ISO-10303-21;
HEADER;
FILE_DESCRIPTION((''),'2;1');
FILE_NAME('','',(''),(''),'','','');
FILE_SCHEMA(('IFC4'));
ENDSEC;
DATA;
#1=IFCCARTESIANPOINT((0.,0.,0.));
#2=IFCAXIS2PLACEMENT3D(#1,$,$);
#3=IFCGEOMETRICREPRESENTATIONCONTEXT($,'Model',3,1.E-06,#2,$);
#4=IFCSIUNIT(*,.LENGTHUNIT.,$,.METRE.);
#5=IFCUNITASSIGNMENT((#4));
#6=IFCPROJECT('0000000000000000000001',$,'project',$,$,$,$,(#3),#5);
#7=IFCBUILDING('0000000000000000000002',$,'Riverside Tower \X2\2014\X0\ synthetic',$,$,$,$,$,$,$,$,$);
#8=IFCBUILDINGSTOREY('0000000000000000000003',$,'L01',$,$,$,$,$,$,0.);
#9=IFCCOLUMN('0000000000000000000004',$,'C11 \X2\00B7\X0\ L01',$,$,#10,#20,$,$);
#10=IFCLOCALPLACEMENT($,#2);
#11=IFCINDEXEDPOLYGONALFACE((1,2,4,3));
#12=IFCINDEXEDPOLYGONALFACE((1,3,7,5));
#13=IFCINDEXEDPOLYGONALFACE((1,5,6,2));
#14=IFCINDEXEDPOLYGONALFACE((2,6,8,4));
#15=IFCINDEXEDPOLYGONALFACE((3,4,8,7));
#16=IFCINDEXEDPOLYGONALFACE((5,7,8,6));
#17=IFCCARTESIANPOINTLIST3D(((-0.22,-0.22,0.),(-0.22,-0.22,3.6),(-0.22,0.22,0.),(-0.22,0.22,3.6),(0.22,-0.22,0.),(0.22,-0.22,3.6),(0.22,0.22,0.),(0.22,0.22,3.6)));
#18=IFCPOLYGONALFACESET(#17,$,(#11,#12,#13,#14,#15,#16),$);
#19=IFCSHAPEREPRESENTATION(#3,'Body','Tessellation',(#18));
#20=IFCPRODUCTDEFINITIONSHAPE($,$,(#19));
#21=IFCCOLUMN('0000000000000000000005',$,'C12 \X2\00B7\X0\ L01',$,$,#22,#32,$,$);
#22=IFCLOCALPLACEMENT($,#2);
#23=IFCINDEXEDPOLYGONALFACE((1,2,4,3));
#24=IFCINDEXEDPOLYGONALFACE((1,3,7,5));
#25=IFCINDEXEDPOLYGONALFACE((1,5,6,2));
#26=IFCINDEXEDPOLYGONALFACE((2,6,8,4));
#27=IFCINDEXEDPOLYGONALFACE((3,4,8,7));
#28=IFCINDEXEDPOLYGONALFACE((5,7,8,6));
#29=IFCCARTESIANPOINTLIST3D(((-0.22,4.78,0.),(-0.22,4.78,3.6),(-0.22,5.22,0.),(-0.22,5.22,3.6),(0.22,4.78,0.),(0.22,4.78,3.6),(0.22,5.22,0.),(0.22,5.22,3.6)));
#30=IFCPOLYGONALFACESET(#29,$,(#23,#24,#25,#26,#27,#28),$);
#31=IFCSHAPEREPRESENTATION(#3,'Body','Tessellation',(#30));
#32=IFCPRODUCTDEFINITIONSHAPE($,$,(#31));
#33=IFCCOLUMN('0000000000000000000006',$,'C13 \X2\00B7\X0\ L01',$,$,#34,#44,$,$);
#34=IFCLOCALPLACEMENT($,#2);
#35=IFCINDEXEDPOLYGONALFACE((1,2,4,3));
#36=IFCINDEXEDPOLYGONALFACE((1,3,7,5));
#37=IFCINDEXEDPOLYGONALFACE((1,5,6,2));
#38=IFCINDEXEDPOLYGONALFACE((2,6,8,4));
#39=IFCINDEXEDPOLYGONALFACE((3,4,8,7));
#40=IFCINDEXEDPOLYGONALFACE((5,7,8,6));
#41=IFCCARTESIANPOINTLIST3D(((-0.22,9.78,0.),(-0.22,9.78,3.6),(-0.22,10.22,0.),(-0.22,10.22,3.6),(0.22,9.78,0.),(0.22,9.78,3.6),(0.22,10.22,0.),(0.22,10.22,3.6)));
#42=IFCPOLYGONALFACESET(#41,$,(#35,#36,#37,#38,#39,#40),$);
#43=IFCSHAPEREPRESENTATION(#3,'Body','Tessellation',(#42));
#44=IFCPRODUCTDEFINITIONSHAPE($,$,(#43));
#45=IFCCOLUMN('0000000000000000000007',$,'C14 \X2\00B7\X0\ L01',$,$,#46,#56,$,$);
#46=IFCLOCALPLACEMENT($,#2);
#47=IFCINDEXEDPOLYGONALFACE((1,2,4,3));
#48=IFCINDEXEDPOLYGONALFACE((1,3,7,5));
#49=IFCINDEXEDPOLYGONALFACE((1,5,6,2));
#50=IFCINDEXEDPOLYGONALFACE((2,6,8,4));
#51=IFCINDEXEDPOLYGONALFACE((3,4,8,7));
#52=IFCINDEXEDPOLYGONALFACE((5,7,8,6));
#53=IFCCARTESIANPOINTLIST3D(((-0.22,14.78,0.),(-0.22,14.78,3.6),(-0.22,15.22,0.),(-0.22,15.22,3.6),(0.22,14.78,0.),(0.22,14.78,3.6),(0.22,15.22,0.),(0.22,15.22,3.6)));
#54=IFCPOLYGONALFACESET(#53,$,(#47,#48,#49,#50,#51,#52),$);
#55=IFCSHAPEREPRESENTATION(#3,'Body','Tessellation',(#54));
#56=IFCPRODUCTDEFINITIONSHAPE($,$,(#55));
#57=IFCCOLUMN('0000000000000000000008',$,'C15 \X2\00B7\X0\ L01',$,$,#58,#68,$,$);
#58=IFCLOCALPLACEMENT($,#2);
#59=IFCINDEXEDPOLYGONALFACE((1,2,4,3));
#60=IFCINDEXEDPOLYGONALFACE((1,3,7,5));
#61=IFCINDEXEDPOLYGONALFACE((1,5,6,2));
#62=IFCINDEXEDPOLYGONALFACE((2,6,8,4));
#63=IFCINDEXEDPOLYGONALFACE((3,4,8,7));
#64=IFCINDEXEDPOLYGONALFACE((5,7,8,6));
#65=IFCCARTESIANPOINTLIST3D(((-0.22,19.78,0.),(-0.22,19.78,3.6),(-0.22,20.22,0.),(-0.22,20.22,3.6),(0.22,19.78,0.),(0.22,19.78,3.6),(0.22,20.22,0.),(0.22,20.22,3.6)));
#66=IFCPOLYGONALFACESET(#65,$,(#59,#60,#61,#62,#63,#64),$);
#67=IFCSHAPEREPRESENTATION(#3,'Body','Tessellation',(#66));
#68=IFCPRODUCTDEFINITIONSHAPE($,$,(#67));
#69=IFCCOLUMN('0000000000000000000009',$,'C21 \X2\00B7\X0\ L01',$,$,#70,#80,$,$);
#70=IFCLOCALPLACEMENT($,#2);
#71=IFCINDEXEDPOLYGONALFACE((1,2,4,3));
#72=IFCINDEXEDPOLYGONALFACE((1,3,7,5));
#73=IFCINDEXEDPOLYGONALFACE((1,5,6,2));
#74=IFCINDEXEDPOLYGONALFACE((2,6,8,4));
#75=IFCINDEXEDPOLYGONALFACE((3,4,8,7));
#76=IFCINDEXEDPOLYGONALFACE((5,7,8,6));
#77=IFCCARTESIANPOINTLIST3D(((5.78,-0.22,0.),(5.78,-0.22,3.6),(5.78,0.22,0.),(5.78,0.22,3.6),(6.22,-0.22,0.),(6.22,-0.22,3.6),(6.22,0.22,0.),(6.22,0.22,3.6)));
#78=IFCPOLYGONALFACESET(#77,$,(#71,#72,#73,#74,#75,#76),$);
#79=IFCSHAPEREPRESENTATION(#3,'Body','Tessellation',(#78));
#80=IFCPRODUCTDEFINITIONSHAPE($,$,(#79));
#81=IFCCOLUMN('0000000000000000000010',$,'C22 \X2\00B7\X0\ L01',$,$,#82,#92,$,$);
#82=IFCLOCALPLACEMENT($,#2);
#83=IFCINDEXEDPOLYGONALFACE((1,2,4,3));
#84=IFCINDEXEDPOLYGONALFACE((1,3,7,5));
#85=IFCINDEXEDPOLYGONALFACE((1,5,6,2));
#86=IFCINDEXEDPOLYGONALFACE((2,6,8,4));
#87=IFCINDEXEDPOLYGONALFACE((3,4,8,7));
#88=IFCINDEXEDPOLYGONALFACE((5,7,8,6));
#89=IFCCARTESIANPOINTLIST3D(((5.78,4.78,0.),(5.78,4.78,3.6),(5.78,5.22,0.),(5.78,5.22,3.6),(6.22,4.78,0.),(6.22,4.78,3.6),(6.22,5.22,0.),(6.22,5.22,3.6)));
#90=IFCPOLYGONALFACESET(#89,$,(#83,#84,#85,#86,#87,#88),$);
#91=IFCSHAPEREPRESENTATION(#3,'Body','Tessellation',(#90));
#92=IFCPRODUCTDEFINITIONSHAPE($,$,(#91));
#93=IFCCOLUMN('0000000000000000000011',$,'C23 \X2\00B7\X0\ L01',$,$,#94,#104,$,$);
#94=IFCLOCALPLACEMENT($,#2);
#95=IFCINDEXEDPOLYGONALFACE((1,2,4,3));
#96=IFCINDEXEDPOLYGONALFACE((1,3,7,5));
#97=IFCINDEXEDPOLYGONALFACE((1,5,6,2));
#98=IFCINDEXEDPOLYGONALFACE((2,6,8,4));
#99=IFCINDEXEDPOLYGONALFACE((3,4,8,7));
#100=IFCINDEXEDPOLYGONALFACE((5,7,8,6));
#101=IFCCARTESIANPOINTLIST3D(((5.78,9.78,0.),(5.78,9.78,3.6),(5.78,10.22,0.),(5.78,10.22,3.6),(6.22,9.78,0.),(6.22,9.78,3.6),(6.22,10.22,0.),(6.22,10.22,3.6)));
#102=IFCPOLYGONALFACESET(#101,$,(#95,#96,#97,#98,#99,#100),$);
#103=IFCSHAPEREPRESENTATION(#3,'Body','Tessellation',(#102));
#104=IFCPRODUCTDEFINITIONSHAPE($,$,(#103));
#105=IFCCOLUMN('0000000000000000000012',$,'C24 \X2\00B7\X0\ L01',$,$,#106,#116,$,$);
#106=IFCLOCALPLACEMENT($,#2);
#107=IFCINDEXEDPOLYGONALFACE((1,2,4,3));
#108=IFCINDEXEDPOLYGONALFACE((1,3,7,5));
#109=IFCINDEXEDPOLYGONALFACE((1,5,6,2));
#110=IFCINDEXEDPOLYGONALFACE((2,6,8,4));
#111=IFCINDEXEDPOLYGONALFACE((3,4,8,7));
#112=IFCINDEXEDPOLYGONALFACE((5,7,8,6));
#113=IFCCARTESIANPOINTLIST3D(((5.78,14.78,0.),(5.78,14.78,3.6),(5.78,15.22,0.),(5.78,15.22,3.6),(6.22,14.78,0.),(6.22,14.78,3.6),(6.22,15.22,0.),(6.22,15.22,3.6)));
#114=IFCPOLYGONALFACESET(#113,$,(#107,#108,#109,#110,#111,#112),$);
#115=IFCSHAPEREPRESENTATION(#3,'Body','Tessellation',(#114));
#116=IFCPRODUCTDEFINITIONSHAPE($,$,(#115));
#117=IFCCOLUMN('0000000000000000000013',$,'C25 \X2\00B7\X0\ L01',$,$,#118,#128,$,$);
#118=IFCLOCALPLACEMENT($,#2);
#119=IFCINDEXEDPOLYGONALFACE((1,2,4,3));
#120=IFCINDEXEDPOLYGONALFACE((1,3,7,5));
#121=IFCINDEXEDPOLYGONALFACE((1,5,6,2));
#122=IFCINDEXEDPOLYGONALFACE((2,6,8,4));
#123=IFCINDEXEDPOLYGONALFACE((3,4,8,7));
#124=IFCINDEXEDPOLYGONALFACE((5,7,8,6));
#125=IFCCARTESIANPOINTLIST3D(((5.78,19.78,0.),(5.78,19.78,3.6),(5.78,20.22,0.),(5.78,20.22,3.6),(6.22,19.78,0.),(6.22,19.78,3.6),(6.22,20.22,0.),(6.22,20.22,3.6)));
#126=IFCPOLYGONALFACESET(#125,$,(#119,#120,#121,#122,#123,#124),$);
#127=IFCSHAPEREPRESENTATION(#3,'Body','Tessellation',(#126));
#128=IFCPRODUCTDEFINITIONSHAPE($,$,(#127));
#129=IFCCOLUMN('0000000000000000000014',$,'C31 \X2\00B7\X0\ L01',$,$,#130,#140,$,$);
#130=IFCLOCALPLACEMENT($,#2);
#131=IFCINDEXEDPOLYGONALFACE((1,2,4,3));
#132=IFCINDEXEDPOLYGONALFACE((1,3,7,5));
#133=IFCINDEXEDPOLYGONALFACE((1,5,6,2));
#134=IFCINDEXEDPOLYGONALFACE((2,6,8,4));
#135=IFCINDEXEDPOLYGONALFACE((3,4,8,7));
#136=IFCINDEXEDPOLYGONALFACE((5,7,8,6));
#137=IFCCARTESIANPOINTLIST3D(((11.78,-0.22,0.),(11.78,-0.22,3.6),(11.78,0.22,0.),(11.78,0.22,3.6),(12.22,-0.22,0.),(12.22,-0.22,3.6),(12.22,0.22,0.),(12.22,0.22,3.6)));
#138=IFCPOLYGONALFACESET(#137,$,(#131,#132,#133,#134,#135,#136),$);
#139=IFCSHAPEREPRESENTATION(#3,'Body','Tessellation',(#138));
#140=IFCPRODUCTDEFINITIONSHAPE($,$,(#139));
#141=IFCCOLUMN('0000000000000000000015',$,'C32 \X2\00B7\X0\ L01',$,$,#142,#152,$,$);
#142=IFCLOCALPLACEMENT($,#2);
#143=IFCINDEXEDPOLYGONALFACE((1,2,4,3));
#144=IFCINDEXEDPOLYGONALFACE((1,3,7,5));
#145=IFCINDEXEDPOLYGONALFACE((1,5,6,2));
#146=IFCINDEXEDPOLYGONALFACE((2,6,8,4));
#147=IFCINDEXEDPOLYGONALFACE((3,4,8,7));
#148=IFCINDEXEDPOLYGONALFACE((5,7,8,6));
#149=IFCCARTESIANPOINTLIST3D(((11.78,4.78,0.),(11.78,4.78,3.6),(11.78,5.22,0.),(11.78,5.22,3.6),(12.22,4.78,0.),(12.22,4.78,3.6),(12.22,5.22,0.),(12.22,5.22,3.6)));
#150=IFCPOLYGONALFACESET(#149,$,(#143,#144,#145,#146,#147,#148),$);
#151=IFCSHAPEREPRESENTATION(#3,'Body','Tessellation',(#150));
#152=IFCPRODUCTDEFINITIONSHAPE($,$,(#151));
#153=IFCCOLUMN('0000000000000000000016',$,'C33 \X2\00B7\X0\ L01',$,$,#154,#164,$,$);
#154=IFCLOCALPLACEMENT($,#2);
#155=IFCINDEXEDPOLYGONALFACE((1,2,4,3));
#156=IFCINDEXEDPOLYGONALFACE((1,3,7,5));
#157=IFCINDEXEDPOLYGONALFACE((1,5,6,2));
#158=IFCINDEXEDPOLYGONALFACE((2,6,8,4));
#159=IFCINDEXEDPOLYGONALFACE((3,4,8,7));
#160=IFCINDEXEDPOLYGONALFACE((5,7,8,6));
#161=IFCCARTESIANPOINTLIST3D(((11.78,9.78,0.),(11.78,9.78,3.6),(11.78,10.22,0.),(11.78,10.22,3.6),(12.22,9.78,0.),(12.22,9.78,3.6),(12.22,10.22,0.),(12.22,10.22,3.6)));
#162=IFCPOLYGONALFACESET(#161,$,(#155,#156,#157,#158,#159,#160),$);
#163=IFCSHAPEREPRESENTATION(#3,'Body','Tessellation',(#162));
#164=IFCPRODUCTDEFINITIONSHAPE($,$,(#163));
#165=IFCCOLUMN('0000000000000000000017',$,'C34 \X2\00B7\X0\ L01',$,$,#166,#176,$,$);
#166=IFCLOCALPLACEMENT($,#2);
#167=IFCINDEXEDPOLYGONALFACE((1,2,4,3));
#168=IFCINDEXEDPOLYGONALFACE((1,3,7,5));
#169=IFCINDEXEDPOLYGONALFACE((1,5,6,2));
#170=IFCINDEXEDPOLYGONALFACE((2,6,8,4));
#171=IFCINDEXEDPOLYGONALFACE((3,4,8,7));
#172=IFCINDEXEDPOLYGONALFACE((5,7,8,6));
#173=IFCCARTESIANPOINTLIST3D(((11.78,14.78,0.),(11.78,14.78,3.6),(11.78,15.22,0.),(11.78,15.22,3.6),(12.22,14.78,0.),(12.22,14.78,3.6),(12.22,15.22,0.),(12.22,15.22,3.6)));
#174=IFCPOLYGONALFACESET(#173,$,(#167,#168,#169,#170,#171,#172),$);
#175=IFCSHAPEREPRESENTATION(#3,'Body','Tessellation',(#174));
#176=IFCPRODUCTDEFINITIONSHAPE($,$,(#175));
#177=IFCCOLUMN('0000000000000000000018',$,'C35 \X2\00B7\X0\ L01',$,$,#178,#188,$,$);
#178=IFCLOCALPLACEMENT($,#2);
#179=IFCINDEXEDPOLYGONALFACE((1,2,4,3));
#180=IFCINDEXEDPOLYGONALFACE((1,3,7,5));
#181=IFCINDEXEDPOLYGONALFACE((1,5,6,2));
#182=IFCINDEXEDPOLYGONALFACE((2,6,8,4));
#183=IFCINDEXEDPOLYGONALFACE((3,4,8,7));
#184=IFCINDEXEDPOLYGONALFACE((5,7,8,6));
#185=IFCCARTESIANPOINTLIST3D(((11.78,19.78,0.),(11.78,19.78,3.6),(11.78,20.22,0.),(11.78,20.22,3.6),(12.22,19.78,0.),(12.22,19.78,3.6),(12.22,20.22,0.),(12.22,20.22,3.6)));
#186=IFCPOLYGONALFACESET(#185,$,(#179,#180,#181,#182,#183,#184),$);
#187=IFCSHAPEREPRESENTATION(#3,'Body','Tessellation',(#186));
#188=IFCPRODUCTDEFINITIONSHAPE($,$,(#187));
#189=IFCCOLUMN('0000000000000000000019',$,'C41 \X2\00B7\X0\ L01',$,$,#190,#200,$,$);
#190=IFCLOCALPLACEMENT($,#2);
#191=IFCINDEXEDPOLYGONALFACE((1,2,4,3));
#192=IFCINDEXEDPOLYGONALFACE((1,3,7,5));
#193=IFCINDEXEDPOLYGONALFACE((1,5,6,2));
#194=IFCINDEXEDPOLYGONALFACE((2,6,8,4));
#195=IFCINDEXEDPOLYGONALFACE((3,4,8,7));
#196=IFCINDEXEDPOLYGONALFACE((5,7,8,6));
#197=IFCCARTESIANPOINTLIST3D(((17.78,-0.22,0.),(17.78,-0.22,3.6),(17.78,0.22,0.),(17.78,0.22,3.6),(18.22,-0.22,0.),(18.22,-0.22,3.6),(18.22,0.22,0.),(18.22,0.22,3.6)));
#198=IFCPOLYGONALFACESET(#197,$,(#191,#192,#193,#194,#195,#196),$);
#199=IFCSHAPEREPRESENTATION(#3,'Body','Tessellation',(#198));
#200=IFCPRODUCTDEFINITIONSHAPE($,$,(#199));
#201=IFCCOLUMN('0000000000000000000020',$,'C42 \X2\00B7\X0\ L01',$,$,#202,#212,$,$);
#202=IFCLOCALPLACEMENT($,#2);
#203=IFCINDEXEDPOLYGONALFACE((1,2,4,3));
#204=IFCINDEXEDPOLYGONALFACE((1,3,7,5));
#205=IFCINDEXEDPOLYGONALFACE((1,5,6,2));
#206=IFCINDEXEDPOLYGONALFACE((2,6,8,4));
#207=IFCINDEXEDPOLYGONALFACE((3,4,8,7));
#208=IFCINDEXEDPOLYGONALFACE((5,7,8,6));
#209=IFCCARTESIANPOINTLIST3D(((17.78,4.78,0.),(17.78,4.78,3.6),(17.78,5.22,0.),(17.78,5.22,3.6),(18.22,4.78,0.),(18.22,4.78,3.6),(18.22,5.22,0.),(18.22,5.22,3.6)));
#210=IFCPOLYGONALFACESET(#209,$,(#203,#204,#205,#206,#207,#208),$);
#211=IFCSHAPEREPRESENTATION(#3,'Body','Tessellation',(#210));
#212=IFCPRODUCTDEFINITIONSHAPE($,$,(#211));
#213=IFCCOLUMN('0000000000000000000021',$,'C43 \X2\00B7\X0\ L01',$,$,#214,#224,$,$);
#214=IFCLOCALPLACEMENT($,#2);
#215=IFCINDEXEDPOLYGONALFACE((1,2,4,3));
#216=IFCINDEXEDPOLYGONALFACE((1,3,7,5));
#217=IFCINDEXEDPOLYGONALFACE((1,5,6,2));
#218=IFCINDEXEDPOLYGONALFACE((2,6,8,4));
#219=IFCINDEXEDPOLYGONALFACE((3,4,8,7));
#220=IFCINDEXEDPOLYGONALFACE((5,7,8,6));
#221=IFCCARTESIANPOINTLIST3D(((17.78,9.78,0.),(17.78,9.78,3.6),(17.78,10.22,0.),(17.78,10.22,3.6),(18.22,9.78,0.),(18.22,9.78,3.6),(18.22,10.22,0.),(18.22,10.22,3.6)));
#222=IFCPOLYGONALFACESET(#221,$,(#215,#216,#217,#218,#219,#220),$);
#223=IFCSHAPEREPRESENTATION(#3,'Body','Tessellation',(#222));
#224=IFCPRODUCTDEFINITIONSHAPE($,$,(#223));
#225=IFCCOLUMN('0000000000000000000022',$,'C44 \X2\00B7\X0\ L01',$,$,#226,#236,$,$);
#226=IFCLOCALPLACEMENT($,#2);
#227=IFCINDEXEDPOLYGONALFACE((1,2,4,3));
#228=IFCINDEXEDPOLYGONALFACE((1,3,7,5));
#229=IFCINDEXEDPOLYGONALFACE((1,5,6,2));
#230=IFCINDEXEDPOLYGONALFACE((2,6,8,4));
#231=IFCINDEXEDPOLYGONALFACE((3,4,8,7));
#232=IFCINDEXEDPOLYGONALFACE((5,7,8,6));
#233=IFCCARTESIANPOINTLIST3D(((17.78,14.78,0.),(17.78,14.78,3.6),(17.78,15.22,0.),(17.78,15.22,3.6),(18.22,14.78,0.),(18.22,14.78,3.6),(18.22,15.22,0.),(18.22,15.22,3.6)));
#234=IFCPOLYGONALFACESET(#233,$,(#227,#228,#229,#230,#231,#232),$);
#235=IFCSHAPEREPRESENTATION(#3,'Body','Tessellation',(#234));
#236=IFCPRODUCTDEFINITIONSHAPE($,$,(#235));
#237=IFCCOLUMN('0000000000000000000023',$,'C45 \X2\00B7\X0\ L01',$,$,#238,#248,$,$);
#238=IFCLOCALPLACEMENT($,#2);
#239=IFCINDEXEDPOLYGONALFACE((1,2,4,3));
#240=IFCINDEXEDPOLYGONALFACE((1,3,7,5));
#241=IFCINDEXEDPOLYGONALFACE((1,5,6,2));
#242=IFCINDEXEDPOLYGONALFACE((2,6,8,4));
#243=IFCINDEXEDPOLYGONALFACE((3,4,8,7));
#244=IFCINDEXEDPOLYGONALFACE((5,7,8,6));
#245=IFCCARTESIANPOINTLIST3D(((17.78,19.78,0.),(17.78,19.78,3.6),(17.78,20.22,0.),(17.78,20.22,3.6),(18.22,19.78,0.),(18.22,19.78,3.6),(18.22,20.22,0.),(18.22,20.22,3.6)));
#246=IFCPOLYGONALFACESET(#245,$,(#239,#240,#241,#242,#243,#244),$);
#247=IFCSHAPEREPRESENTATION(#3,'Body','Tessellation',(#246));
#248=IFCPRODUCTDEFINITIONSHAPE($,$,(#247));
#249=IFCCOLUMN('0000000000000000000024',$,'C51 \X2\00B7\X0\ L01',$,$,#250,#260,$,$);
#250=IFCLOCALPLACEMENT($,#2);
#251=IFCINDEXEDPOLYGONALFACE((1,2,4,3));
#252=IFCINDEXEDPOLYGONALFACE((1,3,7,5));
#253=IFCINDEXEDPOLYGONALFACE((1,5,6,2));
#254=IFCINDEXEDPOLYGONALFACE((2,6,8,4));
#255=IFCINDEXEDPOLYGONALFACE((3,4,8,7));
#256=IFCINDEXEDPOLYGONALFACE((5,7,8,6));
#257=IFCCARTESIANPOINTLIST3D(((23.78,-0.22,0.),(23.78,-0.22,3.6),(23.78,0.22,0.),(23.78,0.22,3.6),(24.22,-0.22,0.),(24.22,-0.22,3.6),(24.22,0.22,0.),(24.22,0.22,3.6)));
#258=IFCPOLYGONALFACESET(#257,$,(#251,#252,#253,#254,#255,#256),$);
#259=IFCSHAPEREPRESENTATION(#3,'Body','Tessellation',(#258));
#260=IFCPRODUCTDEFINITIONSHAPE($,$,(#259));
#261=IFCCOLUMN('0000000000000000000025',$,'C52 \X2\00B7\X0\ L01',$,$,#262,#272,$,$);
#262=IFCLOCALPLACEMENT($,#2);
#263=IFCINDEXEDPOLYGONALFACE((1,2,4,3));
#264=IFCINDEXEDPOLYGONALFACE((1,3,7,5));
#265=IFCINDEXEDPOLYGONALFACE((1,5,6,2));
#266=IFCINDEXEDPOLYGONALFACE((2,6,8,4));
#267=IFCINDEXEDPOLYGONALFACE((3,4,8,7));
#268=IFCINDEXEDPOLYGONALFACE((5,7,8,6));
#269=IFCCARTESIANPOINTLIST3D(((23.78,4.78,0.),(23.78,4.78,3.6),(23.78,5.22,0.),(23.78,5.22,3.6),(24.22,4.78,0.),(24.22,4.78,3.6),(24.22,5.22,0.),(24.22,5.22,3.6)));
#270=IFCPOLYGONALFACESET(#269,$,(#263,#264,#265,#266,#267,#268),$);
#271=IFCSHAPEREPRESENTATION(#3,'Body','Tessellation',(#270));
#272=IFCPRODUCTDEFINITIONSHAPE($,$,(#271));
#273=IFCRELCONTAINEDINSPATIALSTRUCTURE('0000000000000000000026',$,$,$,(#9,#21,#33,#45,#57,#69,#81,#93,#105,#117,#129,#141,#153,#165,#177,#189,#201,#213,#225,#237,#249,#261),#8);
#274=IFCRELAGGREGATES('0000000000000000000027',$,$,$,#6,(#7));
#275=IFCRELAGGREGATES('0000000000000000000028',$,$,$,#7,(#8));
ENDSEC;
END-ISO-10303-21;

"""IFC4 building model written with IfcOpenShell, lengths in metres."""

from ifc_helpers import new_model, si_unit, frame, origin, place, context, project, spatial, rectangle, extrude, element, save


model = new_model("IFC4")

# Units and contexts
model_context = context("Model", 3, precision=1e-06, world=origin())
ifc_project = project(units=[si_unit("LENGTHUNIT", "METRE")], contexts=[model_context])

# Building, storey
building = spatial("IfcBuilding", under=ifc_project, Name="Riverside Tower — synthetic")
storey = spatial("IfcBuildingStorey", under=building, Name="L01", Elevation=0.0)

# Columns
for number, where, name in (
    (1, (0.0, 0.0, 0.0), "C11 · L01"),
    (2, (0.0, 5.0, 0.0), "C12 · L01"),
    (3, (0.0, 10.0, 0.0), "C13 · L01"),
    (4, (0.0, 15.0, 0.0), "C14 · L01"),
    (5, (0.0, 20.0, 0.0), "C15 · L01"),
    (6, (6.0, 0.0, 0.0), "C21 · L01"),
    (7, (6.0, 5.0, 0.0), "C22 · L01"),
    (8, (6.0, 10.0, 0.0), "C23 · L01"),
    (9, (6.0, 15.0, 0.0), "C24 · L01"),
    (10, (6.0, 20.0, 0.0), "C25 · L01"),
    (11, (12.0, 0.0, 0.0), "C31 · L01"),
    (12, (12.0, 5.0, 0.0), "C32 · L01"),
    (13, (12.0, 10.0, 0.0), "C33 · L01"),
    (14, (12.0, 15.0, 0.0), "C34 · L01"),
    (15, (12.0, 20.0, 0.0), "C35 · L01"),
    (16, (18.0, 0.0, 0.0), "C41 · L01"),
    (17, (18.0, 5.0, 0.0), "C42 · L01"),
    (18, (18.0, 10.0, 0.0), "C43 · L01"),
    (19, (18.0, 15.0, 0.0), "C44 · L01"),
    (20, (18.0, 20.0, 0.0), "C45 · L01"),
    (21, (24.0, 0.0, 0.0), "C51 · L01"),
    (22, (24.0, 5.0, 0.0), "C52 · L01"),
):
    element("IfcColumn", number, at=place(None, frame(where)), inside=storey, Name=name, context=model_context, shape_type="SweptSolid", body=[
        extrude(rectangle(XDim=0.44, YDim=0.44), origin(), (0.0, 0.0, 1.0), 3.6),
    ])

save(model, "model.ifc")
